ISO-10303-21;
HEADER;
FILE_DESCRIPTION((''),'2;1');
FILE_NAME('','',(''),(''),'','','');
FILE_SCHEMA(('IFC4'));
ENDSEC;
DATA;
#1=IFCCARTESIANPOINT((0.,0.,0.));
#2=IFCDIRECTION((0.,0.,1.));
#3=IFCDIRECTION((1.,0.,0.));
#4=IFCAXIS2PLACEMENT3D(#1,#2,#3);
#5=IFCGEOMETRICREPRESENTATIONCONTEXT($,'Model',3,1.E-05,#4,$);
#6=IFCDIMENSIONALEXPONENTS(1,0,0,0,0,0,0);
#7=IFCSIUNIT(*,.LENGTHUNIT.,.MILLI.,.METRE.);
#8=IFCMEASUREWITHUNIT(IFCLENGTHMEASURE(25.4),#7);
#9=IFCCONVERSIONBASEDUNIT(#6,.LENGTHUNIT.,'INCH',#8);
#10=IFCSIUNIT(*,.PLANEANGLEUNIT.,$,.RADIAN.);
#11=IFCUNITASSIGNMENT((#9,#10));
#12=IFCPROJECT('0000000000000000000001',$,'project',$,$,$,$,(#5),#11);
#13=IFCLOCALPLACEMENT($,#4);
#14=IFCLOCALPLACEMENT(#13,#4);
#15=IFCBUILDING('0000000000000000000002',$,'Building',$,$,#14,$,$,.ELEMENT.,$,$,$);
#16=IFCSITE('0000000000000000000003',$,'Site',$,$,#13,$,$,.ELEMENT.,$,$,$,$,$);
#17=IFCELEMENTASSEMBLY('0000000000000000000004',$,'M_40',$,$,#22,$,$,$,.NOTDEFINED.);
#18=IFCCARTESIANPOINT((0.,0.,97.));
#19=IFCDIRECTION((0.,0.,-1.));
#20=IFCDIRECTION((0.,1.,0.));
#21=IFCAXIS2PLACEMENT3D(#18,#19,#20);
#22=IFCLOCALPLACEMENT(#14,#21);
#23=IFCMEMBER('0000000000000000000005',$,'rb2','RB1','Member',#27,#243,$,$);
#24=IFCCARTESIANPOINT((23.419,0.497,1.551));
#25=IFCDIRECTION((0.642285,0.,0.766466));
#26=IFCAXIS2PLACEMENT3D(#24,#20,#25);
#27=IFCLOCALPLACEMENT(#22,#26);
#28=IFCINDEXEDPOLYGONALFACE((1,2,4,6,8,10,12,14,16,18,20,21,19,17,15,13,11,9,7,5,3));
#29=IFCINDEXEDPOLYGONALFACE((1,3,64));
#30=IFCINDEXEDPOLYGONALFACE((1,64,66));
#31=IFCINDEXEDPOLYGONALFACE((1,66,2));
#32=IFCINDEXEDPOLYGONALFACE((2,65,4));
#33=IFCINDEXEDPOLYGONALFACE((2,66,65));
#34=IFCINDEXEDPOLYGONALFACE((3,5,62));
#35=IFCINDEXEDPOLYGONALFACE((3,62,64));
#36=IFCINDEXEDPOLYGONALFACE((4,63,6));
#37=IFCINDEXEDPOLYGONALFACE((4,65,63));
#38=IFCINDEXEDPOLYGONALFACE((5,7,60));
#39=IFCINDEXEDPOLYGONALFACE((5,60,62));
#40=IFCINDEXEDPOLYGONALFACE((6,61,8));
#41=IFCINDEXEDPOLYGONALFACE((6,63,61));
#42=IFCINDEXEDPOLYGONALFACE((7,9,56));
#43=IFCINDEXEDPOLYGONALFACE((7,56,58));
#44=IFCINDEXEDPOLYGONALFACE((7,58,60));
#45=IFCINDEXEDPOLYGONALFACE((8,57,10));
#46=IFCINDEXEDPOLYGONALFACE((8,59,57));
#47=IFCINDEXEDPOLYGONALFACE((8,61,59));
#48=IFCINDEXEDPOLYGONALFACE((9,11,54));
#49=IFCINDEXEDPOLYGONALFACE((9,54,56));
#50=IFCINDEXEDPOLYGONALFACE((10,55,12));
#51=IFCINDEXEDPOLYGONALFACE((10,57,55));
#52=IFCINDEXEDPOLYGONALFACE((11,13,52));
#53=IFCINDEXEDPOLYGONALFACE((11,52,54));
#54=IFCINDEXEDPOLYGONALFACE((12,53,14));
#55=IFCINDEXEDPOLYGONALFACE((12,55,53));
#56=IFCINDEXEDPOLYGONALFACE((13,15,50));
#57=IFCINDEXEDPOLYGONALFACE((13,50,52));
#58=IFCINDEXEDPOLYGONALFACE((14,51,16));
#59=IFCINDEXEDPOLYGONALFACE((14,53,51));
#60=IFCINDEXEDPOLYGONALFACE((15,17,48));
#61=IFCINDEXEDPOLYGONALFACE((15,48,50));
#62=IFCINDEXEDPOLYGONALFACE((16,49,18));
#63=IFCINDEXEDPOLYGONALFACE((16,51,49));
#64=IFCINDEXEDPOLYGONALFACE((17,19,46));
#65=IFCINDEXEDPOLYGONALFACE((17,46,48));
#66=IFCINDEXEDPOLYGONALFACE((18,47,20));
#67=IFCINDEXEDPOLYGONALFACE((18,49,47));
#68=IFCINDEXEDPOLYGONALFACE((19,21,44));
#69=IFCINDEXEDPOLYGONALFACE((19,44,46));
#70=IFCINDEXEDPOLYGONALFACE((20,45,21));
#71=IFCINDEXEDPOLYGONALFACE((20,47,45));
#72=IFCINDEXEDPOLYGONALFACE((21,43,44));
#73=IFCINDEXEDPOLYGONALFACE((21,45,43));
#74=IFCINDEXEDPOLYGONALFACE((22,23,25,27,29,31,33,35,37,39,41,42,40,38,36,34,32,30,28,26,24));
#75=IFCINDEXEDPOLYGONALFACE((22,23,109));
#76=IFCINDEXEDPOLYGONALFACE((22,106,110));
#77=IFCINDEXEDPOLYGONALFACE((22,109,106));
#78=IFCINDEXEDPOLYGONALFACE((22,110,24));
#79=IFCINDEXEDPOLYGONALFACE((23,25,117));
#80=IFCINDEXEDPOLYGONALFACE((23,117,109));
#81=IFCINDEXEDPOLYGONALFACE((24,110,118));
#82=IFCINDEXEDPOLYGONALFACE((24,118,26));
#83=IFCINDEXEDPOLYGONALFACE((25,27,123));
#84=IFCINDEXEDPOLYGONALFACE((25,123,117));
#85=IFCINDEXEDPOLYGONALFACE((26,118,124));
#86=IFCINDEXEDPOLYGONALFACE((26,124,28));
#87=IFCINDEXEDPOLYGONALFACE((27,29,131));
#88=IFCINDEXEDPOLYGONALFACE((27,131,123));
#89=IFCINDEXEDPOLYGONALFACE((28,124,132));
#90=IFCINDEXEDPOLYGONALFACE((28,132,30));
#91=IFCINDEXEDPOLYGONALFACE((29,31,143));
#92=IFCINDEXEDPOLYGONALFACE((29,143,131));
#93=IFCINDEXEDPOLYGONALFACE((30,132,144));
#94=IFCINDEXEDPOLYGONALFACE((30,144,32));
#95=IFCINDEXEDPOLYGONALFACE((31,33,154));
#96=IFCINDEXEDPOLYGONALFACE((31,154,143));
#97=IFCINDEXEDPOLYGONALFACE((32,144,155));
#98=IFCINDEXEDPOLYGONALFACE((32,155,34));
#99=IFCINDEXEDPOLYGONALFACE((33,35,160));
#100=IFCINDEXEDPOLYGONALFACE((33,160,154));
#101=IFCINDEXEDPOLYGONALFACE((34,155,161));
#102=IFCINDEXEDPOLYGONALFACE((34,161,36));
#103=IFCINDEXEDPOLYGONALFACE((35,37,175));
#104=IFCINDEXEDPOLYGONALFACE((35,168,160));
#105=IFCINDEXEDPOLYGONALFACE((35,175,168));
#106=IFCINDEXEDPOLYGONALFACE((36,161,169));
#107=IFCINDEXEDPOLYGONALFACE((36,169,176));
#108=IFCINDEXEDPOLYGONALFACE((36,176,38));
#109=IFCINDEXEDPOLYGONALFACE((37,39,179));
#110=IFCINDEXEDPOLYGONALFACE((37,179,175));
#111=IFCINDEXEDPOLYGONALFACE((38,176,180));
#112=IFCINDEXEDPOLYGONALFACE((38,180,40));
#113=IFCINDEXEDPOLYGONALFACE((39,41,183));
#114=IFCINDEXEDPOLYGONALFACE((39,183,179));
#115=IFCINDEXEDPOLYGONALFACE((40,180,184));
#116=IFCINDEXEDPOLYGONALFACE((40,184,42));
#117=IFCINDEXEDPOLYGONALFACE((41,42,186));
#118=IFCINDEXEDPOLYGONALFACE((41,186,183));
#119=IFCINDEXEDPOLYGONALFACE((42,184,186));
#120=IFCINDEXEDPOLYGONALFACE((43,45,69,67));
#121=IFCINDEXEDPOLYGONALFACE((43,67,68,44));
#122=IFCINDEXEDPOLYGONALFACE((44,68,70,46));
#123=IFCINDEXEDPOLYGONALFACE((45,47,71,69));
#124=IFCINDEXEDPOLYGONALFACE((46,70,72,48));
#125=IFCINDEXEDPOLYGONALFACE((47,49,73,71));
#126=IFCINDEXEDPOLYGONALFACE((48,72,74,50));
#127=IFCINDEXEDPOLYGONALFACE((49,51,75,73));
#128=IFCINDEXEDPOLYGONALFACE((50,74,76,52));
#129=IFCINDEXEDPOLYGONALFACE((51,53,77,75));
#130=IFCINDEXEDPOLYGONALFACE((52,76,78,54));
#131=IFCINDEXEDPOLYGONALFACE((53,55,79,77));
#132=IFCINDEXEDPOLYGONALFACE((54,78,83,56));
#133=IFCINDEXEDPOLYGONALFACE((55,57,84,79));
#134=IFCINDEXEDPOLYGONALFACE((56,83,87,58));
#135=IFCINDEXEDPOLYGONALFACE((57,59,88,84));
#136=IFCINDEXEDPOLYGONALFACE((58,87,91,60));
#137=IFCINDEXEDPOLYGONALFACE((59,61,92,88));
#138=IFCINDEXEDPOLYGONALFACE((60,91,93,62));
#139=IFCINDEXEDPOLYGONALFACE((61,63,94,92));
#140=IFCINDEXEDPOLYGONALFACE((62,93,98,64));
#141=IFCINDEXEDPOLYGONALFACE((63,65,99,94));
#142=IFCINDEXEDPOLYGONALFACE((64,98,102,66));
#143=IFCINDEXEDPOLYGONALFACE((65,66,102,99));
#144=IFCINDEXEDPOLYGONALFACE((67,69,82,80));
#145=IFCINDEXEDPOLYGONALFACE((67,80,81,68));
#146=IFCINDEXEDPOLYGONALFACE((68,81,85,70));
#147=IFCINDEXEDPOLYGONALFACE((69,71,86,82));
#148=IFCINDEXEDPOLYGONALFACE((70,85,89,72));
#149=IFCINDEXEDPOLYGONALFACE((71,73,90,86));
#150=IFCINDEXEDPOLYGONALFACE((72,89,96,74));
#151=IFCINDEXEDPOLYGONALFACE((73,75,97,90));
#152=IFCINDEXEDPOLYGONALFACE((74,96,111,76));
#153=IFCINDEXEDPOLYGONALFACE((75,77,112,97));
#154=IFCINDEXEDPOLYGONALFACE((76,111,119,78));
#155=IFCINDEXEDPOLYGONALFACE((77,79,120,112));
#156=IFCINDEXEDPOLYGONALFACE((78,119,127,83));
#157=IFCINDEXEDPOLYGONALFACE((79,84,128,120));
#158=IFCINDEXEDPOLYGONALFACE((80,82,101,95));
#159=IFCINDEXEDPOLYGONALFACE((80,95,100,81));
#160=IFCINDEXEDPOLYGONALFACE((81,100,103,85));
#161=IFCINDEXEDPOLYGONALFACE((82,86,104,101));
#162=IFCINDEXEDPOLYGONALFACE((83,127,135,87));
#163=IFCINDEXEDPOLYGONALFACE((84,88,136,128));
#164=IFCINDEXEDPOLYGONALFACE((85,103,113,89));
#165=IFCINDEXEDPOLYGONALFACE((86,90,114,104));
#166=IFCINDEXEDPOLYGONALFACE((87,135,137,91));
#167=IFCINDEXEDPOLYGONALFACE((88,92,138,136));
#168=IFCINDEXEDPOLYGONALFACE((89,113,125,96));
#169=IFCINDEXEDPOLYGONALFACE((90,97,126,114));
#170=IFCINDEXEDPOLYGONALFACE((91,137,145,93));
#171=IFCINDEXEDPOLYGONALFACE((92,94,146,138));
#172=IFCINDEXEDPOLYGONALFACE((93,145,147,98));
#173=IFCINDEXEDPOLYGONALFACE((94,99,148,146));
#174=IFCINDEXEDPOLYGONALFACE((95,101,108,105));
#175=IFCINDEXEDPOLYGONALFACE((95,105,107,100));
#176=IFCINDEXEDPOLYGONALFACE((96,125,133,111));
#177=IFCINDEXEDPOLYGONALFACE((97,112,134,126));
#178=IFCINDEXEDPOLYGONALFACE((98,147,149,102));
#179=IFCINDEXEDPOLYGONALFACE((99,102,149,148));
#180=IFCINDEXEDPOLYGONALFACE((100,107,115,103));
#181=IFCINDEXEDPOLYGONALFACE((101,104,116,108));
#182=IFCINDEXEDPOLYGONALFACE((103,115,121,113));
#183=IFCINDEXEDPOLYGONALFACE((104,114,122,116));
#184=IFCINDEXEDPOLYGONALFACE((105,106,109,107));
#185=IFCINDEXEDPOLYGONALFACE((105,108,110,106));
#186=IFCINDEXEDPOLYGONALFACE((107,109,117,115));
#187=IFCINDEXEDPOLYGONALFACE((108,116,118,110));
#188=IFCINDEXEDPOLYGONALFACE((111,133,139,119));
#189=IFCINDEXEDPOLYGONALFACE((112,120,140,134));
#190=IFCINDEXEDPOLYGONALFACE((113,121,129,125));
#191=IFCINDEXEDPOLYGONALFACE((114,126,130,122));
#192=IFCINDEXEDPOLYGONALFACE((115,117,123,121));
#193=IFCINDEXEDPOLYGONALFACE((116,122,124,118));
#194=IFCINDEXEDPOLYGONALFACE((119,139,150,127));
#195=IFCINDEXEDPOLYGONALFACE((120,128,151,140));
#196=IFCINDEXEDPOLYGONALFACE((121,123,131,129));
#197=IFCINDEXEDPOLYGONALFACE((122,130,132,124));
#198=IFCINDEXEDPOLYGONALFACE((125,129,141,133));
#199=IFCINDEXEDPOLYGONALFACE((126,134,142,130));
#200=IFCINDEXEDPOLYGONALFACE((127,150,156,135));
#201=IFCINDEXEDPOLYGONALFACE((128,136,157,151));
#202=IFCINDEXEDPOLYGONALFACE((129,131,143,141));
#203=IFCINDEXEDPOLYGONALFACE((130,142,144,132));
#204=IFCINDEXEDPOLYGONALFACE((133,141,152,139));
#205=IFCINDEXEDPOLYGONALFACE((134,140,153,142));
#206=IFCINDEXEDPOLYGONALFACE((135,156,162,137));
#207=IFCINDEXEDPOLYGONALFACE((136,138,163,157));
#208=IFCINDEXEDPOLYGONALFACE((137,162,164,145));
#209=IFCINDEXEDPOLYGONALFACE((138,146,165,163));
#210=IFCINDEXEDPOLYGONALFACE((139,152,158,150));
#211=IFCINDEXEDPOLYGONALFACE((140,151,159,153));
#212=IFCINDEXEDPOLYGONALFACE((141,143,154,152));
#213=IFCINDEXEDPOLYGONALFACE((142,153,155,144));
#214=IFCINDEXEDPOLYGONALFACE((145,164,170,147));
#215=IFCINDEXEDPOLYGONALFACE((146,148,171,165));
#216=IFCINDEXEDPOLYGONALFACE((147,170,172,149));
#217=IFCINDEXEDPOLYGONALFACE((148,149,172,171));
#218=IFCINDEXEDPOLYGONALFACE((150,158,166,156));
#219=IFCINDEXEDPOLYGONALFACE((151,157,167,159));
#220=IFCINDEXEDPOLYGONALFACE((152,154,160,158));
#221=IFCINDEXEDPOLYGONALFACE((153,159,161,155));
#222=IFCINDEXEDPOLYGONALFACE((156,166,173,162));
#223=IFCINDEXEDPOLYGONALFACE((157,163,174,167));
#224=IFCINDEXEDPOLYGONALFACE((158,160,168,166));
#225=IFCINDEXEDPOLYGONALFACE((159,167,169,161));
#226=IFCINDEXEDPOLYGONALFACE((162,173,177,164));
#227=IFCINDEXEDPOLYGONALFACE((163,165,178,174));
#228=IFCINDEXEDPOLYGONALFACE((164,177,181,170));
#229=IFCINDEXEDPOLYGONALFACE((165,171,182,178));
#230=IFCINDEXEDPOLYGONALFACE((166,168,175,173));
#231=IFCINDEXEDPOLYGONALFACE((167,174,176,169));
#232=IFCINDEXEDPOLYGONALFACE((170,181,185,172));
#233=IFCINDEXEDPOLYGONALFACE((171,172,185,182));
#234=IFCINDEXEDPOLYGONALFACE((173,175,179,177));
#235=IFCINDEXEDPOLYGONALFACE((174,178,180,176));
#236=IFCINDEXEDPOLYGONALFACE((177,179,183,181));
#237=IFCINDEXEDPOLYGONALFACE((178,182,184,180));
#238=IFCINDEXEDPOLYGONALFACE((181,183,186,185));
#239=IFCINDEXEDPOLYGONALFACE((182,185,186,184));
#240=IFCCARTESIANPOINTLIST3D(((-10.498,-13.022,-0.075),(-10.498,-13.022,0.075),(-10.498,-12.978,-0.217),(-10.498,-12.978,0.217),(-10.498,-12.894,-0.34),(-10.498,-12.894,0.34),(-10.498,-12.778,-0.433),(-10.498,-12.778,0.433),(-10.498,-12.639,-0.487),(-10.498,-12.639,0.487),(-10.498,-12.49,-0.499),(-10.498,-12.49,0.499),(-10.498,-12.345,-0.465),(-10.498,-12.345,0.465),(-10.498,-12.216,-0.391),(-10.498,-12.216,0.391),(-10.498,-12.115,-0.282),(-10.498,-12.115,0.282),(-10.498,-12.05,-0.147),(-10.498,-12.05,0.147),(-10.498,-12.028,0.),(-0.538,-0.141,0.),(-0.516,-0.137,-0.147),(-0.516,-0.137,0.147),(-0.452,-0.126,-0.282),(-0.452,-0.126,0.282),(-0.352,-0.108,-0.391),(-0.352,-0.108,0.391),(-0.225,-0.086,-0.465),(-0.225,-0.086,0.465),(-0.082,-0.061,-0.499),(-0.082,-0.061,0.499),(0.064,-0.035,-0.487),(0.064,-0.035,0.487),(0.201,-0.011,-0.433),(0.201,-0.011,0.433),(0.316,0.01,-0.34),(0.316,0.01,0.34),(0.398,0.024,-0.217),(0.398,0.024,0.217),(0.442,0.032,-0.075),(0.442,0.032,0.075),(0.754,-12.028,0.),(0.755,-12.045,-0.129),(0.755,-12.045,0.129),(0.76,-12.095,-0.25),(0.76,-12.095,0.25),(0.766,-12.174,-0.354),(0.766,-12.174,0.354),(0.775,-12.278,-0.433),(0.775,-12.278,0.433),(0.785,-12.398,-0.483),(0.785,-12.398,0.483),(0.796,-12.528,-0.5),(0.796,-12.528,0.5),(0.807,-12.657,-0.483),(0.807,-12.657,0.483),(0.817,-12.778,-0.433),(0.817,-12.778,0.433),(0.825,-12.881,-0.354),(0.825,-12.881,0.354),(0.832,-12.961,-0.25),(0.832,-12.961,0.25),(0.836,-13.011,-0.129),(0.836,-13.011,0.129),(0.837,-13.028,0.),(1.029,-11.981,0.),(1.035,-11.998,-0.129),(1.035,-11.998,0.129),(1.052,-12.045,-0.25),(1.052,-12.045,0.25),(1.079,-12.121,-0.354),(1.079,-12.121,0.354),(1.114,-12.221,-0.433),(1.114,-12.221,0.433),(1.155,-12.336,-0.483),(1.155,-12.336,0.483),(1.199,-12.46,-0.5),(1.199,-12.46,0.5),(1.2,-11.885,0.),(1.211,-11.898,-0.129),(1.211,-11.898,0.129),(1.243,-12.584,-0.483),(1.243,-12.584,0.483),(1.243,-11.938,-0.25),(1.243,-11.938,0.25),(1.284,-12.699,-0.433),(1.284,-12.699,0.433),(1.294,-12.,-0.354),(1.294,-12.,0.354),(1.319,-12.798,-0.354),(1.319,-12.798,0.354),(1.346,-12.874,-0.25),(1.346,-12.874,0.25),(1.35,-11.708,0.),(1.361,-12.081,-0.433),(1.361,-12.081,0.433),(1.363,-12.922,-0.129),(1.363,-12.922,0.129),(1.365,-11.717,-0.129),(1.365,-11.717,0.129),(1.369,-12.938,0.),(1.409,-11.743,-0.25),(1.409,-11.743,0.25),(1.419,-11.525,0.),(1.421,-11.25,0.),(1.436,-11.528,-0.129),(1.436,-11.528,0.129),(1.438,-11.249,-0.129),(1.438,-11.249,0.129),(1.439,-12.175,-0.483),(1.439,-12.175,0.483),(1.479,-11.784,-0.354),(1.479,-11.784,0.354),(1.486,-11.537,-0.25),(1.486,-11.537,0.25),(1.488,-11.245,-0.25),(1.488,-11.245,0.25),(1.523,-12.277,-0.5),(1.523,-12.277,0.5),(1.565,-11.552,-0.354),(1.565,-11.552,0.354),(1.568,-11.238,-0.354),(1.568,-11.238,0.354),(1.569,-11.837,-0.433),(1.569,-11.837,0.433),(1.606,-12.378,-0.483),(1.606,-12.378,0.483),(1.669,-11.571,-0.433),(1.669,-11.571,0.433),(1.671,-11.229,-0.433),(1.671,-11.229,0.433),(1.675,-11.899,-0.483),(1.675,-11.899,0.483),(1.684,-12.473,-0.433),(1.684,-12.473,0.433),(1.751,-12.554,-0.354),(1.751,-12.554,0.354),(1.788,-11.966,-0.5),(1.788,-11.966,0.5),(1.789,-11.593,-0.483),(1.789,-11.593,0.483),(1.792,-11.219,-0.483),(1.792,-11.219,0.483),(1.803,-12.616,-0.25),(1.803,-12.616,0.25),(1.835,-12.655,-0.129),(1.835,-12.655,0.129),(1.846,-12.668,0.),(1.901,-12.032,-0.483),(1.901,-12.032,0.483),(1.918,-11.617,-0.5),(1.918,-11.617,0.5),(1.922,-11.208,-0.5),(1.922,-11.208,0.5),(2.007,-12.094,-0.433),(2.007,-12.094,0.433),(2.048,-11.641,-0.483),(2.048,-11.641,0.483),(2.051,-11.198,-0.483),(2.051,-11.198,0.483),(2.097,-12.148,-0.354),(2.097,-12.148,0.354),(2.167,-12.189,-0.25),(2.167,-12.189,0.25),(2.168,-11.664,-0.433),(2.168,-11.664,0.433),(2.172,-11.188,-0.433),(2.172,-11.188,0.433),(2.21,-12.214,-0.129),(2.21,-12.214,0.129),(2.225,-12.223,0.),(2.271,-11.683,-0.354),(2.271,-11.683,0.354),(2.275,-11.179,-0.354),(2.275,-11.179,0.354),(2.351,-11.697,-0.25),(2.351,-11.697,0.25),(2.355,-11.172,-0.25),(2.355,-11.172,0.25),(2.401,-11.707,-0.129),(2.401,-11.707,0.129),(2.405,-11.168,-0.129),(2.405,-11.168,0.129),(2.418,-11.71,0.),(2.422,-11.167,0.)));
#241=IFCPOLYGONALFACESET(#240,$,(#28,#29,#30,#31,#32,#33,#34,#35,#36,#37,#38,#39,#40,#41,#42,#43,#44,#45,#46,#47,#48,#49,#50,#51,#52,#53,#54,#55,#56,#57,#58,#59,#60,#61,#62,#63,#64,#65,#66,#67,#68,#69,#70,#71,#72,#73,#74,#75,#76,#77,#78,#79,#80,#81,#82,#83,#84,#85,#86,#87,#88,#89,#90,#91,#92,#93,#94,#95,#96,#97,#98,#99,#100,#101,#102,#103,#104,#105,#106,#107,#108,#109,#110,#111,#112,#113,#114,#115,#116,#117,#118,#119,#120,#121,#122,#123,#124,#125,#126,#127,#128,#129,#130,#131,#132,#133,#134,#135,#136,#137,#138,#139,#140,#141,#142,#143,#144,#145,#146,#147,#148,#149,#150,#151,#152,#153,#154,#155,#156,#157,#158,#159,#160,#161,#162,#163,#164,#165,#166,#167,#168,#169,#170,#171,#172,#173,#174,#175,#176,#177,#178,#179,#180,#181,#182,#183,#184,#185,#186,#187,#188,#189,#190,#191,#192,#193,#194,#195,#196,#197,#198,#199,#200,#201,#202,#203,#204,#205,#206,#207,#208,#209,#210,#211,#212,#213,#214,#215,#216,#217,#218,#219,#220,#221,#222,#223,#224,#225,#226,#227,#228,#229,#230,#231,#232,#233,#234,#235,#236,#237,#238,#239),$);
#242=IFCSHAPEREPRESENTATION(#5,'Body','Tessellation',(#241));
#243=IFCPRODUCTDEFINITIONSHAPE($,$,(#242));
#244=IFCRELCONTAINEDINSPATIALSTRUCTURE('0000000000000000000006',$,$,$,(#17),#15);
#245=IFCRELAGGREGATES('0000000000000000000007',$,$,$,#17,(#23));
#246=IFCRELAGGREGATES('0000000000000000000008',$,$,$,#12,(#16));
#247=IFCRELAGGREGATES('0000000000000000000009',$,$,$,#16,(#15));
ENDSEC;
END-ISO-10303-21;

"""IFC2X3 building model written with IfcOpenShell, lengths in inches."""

from ifc_helpers import new_model, entity, si_unit, converted_unit, frame, origin_with_axes, place, context, project, spatial, element, aggregate, save


model = new_model("IFC2X3")

# Units and contexts
model_context = context("Model", 3, precision=1e-05, world=origin_with_axes())
ifc_project = project(units=[converted_unit("LENGTHUNIT", "INCH", entity("IfcLengthMeasure", 25.4), si_unit("LENGTHUNIT", "METRE", prefix="MILLI"), dimensions=[1, 0, 0, 0, 0, 0, 0]), si_unit("PLANEANGLEUNIT", "RADIAN")], contexts=[model_context])

# Site, building
site_placement = place(None, origin_with_axes())
site = spatial("IfcSite", under=ifc_project, at=site_placement, Name="Site", CompositionType="ELEMENT")
building_placement = place(site_placement, origin_with_axes())
building = spatial("IfcBuilding", under=site, at=building_placement, Name="Building", CompositionType="ELEMENT")

# Element assembly
assembly_1_placement = place(building_placement, frame((0.0, 0.0, 97.0), z_axis=(0.0, 0.0, -1.0), x_axis=(0.0, 1.0, 0.0)))
assembly_1 = element("IfcElementAssembly", 1, at=assembly_1_placement, inside=building, Name="M_40", PredefinedType="NOTDEFINED")

# Member
member_1_placement = place(assembly_1_placement, frame((23.419, 0.497, 1.551), z_axis=(0.0, 1.0, 0.0), x_axis=(0.642285, 0.0, 0.766466)))
cartesian_point_1 = entity("IfcCartesianPoint", [0.0, 0.0, 0.0])
ifc_direction_1 = entity("IfcDirection", [0.0, 0.0, 1.0])
member_1 = element("IfcMember", 2, at=member_1_placement, Name="rb2", Description="RB1", ObjectType="Member", context=model_context, shape_type="SweptSolid", body=[
    entity("IfcSurfaceCurveSweptAreaSolid", entity("IfcCircleProfileDef", "AREA", None, entity("IfcAxis2Placement2D", entity("IfcCartesianPoint", [0.0, 0.0]), entity("IfcDirection", [1.0, 0.0])), 0.5), entity("IfcAxis2Placement3D", cartesian_point_1, ifc_direction_1, entity("IfcDirection", [1.0, 0.0, 0.0])), entity("IfcPolyline", [entity("IfcCartesianPoint", [-0.045, -0.054]), entity("IfcCartesianPoint", [1.921, -11.208]), entity("IfcCartesianPoint", [1.918, -11.617]), entity("IfcCartesianPoint", [1.788, -11.966]), entity("IfcCartesianPoint", [1.523, -12.277]), entity("IfcCartesianPoint", [1.199, -12.46]), entity("IfcCartesianPoint", [0.796, -12.528]), entity("IfcCartesianPoint", [-10.498, -12.528])]), 0.0, 1.0, entity("IfcPlane", entity("IfcAxis2Placement3D", cartesian_point_1, entity("IfcDirection", [0.0, 1.0, 0.0]), ifc_direction_1))),
])
aggregate(assembly_1, [member_1])

save(model, "model.ifc")
